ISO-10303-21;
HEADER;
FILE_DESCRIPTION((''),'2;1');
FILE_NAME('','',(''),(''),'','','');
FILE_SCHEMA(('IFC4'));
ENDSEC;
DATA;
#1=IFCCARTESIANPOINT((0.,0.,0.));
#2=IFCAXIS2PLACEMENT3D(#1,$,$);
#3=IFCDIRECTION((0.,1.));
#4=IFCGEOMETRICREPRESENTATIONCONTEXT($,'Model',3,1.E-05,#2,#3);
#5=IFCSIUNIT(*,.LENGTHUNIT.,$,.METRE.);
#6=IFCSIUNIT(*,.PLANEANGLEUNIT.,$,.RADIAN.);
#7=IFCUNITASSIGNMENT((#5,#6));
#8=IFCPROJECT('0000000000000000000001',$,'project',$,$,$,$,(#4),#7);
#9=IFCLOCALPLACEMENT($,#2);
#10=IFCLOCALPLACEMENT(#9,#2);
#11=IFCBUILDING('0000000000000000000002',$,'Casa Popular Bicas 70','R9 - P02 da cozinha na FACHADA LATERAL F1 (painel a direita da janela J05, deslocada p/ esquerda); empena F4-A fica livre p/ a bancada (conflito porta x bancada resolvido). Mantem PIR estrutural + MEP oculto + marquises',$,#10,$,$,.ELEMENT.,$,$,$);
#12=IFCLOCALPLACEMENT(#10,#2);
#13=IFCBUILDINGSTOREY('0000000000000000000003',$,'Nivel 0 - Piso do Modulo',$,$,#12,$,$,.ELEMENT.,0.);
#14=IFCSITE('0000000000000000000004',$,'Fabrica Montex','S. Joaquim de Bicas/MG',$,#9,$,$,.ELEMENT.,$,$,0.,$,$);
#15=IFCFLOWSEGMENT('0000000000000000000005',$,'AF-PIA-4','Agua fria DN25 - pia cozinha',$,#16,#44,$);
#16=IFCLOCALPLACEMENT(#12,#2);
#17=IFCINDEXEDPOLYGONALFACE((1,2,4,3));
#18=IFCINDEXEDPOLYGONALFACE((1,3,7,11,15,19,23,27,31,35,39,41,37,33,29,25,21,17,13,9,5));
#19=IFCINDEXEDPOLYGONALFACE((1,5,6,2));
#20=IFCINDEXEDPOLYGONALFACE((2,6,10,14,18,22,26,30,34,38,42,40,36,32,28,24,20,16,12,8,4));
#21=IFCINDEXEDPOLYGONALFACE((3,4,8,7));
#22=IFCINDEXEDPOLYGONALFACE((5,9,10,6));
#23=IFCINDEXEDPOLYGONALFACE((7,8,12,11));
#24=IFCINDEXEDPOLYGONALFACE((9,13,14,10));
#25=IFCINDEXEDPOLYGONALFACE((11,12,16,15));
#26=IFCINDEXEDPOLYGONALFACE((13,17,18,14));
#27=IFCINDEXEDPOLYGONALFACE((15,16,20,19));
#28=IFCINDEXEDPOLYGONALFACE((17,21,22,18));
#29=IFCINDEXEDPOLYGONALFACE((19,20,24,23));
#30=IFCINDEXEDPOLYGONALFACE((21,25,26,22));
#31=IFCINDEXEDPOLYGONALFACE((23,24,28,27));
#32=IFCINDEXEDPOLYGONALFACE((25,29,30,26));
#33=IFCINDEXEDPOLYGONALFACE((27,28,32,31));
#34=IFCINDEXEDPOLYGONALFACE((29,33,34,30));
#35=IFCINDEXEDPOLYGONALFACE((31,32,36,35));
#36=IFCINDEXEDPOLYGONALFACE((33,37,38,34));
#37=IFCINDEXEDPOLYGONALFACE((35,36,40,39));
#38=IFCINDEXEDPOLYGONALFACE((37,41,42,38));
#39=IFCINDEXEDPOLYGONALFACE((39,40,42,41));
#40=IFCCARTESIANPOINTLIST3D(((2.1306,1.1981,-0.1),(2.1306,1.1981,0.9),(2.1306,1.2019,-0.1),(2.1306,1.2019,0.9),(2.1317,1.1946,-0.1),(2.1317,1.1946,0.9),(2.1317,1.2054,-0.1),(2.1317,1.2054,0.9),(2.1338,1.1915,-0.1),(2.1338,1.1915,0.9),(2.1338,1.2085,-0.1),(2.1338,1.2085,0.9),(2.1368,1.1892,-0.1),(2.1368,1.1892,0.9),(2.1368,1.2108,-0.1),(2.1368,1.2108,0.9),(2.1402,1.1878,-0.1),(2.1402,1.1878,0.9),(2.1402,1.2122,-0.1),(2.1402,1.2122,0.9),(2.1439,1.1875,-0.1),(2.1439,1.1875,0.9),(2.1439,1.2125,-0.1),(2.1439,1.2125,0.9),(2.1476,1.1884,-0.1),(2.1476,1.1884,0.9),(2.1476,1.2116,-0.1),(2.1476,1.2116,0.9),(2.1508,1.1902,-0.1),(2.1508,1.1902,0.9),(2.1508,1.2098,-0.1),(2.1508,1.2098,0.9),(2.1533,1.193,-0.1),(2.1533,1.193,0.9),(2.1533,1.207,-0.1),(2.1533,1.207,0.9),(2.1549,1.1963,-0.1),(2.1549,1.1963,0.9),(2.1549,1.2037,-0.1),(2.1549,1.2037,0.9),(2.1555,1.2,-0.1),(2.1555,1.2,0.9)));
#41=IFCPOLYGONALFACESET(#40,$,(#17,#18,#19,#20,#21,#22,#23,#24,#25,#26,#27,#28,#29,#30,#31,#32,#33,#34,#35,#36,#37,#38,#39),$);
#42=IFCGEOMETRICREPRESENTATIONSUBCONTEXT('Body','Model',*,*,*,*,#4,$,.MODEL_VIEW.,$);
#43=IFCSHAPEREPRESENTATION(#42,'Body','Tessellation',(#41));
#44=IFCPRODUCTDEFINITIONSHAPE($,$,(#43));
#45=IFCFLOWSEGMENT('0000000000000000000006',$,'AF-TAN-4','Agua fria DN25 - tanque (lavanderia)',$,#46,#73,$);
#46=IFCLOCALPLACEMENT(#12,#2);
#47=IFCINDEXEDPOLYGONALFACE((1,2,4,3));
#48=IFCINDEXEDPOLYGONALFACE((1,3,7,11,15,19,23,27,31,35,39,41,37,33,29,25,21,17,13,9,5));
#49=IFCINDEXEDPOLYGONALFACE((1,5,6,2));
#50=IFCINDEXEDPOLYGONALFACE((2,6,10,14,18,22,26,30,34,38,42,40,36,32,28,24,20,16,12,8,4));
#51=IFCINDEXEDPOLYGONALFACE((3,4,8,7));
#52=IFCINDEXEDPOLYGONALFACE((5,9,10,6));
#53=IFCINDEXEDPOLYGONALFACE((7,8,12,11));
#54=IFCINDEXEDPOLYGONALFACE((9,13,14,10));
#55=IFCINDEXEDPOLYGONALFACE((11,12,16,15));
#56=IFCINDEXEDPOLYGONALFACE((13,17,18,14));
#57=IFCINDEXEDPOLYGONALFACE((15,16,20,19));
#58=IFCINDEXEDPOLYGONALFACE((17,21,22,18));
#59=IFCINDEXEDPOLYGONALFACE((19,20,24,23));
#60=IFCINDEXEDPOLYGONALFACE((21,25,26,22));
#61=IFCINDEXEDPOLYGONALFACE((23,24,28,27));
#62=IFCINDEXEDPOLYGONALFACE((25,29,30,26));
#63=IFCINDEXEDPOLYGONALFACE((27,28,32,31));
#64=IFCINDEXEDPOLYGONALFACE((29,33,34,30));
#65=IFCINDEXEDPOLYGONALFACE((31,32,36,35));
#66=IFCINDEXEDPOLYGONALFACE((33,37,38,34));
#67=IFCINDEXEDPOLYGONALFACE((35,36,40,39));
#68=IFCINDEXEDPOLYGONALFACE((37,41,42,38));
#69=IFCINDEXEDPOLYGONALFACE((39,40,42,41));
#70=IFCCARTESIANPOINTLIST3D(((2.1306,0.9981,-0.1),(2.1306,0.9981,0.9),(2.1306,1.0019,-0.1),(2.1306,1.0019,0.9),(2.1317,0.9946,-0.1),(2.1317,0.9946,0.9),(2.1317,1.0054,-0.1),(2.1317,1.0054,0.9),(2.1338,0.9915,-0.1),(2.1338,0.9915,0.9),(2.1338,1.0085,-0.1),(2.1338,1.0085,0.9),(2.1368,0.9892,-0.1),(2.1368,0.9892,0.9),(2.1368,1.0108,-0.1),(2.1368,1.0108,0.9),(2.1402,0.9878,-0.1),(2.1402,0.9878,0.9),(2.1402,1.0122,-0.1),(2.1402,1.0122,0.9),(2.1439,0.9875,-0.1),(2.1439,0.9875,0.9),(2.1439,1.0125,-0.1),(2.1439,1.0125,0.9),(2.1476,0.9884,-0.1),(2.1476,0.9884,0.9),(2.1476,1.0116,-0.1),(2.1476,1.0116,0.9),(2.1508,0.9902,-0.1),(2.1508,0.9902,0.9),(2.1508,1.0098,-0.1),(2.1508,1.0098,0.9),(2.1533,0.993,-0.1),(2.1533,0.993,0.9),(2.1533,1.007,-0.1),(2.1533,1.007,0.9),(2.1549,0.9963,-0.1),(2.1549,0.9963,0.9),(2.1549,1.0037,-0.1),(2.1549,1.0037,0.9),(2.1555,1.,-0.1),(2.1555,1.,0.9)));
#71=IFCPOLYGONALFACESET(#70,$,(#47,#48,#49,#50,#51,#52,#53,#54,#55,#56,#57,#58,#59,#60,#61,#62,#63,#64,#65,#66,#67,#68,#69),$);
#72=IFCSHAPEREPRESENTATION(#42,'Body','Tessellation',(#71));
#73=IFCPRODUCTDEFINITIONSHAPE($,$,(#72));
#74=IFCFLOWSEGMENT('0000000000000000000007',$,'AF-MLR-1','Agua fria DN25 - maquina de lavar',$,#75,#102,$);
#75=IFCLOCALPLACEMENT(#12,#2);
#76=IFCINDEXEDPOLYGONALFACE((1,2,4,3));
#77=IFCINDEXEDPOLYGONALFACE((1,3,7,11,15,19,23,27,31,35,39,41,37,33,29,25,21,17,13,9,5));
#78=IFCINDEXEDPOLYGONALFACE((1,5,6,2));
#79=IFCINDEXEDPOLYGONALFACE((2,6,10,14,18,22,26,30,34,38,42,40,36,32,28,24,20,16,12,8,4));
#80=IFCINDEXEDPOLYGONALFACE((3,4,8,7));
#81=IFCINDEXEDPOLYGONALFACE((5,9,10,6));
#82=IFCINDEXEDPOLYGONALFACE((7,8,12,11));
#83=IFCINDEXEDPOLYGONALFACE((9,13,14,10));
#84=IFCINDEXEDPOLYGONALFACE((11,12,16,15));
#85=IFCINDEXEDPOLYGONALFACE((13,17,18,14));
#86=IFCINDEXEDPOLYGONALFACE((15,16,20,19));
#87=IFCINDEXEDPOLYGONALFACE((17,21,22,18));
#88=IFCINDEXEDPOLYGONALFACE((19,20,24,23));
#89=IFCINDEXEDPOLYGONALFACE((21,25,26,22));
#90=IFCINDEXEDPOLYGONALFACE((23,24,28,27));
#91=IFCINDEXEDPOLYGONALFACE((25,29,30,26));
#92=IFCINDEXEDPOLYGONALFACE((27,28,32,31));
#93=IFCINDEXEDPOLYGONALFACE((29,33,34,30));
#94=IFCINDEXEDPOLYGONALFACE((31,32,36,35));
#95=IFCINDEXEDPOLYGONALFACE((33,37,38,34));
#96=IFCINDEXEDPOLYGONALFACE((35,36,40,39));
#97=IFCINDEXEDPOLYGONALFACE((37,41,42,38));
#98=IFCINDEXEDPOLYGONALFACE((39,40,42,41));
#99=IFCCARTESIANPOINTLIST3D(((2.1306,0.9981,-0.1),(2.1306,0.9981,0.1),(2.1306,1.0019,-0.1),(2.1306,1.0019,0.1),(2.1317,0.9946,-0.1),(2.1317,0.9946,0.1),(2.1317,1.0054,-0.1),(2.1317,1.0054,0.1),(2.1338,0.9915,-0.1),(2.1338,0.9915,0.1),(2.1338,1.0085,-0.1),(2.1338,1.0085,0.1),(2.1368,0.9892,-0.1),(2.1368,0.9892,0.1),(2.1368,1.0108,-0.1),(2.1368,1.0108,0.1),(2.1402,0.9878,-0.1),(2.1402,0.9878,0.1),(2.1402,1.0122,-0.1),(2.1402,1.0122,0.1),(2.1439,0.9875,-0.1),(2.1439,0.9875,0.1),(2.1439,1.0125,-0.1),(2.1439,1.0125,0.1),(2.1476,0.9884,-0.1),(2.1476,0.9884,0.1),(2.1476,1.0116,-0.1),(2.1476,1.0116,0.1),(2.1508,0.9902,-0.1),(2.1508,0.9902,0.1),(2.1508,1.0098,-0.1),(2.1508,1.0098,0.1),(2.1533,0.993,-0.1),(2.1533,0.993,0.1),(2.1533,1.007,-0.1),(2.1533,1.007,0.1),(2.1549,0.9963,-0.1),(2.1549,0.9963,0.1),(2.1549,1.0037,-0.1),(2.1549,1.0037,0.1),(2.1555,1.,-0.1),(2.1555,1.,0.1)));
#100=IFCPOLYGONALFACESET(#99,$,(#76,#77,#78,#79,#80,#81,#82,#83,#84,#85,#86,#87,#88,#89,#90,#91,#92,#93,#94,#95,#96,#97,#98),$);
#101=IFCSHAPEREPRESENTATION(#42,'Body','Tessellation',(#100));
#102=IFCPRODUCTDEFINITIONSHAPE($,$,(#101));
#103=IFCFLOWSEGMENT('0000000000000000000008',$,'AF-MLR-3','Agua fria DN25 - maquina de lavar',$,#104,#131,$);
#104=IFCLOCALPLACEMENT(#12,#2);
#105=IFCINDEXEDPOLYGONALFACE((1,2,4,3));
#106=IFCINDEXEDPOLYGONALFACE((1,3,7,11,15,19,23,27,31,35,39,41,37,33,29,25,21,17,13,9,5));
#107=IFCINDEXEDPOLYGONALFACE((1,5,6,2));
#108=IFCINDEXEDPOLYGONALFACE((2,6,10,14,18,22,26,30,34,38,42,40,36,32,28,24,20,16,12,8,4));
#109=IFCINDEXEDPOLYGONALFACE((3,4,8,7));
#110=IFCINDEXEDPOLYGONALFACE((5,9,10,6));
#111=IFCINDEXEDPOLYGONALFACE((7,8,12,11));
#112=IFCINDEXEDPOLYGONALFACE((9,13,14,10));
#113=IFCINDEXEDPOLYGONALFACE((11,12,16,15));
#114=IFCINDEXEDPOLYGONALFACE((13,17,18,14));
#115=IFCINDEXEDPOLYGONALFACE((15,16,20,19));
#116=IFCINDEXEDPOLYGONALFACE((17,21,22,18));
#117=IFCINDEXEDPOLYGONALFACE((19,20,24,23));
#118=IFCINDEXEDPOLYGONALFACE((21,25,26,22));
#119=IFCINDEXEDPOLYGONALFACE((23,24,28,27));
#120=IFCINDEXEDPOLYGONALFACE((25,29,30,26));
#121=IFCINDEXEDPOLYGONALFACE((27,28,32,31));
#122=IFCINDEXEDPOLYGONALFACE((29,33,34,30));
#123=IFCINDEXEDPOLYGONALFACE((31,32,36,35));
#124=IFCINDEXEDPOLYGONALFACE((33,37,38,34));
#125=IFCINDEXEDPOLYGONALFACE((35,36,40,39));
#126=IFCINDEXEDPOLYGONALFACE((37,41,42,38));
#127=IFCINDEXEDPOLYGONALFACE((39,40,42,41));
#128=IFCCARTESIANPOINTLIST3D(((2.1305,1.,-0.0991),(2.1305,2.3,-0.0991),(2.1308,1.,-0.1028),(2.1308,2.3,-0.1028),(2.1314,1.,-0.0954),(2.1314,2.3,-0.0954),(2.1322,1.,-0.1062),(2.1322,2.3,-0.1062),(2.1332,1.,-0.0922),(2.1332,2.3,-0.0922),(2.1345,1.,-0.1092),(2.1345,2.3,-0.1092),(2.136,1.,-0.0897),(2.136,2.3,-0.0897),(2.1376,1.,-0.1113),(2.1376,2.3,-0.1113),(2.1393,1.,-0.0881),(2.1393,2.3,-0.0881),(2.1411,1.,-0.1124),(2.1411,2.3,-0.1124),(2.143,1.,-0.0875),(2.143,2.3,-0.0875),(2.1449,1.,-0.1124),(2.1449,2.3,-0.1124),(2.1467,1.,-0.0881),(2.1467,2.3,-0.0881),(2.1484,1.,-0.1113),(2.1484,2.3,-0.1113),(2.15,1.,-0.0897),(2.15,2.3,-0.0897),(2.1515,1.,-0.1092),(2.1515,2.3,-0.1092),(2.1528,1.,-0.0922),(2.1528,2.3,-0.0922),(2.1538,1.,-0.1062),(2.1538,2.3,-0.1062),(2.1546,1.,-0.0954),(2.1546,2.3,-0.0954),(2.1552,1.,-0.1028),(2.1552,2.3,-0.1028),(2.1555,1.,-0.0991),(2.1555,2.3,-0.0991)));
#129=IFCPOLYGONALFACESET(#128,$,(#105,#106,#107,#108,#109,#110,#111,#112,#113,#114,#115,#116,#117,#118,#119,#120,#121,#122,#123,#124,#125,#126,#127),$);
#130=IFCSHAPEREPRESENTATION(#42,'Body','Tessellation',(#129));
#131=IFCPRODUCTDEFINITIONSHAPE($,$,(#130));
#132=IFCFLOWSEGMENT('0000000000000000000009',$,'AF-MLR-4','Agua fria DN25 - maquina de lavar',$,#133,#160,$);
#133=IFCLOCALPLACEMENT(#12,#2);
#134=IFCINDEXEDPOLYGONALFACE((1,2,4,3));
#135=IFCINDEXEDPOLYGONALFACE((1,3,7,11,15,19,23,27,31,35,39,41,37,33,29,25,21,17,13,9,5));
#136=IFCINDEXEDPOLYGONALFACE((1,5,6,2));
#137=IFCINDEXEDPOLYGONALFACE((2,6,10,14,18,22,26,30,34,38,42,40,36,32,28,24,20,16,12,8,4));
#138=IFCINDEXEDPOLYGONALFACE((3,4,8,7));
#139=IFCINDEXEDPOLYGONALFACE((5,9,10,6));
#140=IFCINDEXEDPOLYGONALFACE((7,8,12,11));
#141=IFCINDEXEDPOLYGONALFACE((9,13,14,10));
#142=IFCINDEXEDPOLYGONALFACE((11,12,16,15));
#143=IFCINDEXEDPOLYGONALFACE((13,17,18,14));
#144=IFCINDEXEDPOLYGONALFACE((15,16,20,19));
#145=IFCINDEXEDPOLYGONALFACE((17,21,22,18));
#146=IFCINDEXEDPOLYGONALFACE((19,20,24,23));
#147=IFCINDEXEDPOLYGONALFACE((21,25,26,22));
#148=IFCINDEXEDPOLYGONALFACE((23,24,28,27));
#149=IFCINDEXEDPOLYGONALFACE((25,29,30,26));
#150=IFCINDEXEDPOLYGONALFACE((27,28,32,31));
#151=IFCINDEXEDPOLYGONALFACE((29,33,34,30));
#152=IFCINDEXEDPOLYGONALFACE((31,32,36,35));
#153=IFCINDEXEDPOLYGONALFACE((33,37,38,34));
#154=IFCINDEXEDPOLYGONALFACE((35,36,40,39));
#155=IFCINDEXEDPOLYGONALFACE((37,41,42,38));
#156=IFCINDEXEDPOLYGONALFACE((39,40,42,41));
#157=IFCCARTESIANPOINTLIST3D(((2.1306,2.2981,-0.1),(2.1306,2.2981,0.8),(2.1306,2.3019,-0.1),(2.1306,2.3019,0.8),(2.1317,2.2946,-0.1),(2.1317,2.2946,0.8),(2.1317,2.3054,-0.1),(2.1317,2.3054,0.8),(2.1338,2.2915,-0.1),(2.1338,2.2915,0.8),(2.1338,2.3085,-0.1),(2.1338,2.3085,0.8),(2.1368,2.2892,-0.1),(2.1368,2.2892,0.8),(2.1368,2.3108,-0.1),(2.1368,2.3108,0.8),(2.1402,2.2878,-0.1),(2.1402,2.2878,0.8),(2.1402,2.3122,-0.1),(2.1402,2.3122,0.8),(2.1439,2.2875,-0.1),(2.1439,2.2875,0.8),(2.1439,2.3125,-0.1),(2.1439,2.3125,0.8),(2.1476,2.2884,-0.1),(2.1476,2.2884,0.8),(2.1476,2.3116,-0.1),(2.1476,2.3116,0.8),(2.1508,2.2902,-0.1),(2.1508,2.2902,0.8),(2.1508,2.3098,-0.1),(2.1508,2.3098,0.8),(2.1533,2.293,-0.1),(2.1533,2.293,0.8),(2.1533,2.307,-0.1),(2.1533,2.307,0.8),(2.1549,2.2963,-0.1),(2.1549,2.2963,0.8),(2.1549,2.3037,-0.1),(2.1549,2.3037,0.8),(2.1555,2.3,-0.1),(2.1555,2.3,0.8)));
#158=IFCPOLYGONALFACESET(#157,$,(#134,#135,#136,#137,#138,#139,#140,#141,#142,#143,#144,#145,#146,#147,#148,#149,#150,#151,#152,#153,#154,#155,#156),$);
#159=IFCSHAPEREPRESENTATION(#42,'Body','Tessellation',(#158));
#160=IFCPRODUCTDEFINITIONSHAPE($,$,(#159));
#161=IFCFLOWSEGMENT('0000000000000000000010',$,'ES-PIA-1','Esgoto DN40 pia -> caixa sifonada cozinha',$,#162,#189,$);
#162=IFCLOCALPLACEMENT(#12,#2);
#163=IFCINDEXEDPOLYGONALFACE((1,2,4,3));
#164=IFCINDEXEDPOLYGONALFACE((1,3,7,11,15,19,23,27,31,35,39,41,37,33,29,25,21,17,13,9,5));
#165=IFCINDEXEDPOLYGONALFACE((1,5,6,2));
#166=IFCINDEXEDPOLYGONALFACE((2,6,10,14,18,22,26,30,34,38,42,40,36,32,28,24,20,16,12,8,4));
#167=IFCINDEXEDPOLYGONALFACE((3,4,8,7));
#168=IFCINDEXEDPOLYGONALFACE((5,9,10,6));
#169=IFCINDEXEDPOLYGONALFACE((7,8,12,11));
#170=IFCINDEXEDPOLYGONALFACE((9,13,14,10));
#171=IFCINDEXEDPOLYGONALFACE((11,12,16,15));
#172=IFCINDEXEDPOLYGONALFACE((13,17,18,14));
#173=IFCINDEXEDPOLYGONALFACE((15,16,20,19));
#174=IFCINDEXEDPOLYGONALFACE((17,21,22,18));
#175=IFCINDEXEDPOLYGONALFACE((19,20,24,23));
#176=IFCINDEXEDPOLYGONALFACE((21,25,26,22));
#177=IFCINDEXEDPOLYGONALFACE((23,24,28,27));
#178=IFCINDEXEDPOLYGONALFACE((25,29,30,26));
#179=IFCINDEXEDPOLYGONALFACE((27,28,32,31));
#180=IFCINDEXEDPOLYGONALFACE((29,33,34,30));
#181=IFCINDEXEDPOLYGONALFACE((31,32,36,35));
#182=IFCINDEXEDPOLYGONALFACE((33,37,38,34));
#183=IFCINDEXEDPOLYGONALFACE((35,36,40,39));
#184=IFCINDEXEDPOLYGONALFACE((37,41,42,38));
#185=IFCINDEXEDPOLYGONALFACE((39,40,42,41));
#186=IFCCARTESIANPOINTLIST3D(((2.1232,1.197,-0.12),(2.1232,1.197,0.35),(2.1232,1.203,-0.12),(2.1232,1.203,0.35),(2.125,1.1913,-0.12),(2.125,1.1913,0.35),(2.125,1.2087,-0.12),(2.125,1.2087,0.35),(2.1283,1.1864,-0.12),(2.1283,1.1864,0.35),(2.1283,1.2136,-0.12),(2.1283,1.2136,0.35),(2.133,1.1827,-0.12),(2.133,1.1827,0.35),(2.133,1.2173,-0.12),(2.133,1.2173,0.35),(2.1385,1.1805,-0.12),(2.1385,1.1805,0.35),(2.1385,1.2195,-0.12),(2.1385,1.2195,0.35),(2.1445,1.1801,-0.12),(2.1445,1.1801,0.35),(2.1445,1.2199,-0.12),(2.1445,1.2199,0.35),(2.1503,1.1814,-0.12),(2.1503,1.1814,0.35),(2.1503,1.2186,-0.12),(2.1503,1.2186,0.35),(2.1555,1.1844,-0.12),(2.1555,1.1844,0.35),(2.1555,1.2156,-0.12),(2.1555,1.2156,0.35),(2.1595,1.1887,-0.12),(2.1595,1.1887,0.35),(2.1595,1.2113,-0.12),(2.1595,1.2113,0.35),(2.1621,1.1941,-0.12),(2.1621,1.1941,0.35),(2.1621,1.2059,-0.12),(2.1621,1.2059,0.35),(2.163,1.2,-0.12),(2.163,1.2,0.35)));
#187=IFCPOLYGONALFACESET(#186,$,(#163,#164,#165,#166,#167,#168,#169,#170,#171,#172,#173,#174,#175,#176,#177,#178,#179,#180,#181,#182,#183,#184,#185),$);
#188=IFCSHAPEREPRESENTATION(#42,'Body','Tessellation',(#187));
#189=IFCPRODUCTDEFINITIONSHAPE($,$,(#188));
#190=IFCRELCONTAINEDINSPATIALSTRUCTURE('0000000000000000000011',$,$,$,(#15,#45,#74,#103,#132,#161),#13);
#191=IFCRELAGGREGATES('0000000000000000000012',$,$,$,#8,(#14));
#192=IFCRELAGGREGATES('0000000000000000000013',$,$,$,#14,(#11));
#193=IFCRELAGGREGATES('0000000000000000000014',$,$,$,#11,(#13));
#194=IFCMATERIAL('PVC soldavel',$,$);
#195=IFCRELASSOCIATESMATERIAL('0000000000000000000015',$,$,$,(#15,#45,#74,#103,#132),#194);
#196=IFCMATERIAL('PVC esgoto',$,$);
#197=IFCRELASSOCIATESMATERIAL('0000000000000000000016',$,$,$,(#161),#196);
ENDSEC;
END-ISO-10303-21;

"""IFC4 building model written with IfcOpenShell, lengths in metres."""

from ifc_helpers import new_model, si_unit, direction, frame, origin, origin_2d, place, context, subcontext, project, spatial, circle, extrude, material, element, save


model = new_model("IFC4")

# Units and contexts
model_context = context("Model", 3, precision=1e-05, world=origin(), true_north=direction((0.0, 1.0)))
body_context = subcontext(model_context, "Body", "Model", "MODEL_VIEW")
ifc_project = project(units=[si_unit("LENGTHUNIT", "METRE"), si_unit("PLANEANGLEUNIT", "RADIAN")], contexts=[model_context])

# Site, building, storey
site_placement = place(None, origin())
site = spatial("IfcSite", under=ifc_project, at=site_placement, Name="Fabrica Montex", Description="S. Joaquim de Bicas/MG", CompositionType="ELEMENT", RefElevation=0.0)
building_placement = place(site_placement, origin())
building = spatial("IfcBuilding", under=site, at=building_placement, Name="Casa Popular Bicas 70", Description="R9 - P02 da cozinha na FACHADA LATERAL F1 (painel a direita da janela J05, deslocada p/ esquerda); empena F4-A fica livre p/ a bancada (conflito porta x bancada resolvido). Mantem PIR estrutural + MEP oculto + marquises", CompositionType="ELEMENT")
storey_placement = place(building_placement, origin())
storey = spatial("IfcBuildingStorey", under=building, at=storey_placement, Name="Nivel 0 - Piso do Modulo", CompositionType="ELEMENT", Elevation=0.0)

# Flow segments
ifc_material_1 = material(Name="PVC soldavel")
for number, where, z_axis, x_axis, name, description in (
    (1, (2.143, 1.2, -0.1), (0.0, 0.0, 1.0), (1.0, 0.0, 0.0), "AF-PIA-4", "Agua fria DN25 - pia cozinha"),
    (2, (2.143, 1.0, -0.1), (0.0, 0.0, 1.0), (1.0, 0.0, 0.0), "AF-TAN-4", "Agua fria DN25 - tanque (lavanderia)"),
):
    element("IfcFlowSegment", number, at=place(storey_placement, frame(where, z_axis=z_axis, x_axis=x_axis)), inside=storey, material=ifc_material_1, Name=name, Description=description, context=body_context, shape_type="SweptSolid", body=[
        extrude(circle(Radius=0.0125, at=origin_2d()), origin(), (0.0, 0.0, 1.0), 1.0),
    ])
flow_segment_1_placement = place(storey_placement, frame((2.143, 1.0, 0.1), z_axis=(0.0, 0.0, -1.0), x_axis=(1.0, 0.0, 0.0)))
element("IfcFlowSegment", 3, at=flow_segment_1_placement, inside=storey, material=ifc_material_1, Name="AF-MLR-1", Description="Agua fria DN25 - maquina de lavar", context=body_context, shape_type="SweptSolid", body=[
    extrude(circle(Radius=0.0125, at=origin_2d()), origin(), (0.0, 0.0, 1.0), 0.2),
])
flow_segment_2_placement = place(storey_placement, frame((2.143, 1.0, -0.1), z_axis=(0.0, 1.0, 0.0), x_axis=(0.0, 0.0, 1.0)))
element("IfcFlowSegment", 4, at=flow_segment_2_placement, inside=storey, material=ifc_material_1, Name="AF-MLR-3", Description="Agua fria DN25 - maquina de lavar", context=body_context, shape_type="SweptSolid", body=[
    extrude(circle(Radius=0.0125, at=origin_2d()), origin(), (0.0, 0.0, 1.0), 1.3),
])
flow_segment_3_placement = place(storey_placement, frame((2.143, 2.3, -0.1), z_axis=(0.0, 0.0, 1.0), x_axis=(1.0, 0.0, 0.0)))
element("IfcFlowSegment", 5, at=flow_segment_3_placement, inside=storey, material=ifc_material_1, Name="AF-MLR-4", Description="Agua fria DN25 - maquina de lavar", context=body_context, shape_type="SweptSolid", body=[
    extrude(circle(Radius=0.0125, at=origin_2d()), origin(), (0.0, 0.0, 1.0), 0.9),
])
ifc_material_2 = material(Name="PVC esgoto")
flow_segment_4_placement = place(storey_placement, frame((2.143, 1.2, 0.35), z_axis=(0.0, 0.0, -1.0), x_axis=(1.0, 0.0, 0.0)))
element("IfcFlowSegment", 6, at=flow_segment_4_placement, inside=storey, material=ifc_material_2, Name="ES-PIA-1", Description="Esgoto DN40 pia -> caixa sifonada cozinha", context=body_context, shape_type="SweptSolid", body=[
    extrude(circle(Radius=0.02, at=origin_2d()), origin(), (0.0, 0.0, 1.0), 0.47),
])

save(model, "model.ifc")
